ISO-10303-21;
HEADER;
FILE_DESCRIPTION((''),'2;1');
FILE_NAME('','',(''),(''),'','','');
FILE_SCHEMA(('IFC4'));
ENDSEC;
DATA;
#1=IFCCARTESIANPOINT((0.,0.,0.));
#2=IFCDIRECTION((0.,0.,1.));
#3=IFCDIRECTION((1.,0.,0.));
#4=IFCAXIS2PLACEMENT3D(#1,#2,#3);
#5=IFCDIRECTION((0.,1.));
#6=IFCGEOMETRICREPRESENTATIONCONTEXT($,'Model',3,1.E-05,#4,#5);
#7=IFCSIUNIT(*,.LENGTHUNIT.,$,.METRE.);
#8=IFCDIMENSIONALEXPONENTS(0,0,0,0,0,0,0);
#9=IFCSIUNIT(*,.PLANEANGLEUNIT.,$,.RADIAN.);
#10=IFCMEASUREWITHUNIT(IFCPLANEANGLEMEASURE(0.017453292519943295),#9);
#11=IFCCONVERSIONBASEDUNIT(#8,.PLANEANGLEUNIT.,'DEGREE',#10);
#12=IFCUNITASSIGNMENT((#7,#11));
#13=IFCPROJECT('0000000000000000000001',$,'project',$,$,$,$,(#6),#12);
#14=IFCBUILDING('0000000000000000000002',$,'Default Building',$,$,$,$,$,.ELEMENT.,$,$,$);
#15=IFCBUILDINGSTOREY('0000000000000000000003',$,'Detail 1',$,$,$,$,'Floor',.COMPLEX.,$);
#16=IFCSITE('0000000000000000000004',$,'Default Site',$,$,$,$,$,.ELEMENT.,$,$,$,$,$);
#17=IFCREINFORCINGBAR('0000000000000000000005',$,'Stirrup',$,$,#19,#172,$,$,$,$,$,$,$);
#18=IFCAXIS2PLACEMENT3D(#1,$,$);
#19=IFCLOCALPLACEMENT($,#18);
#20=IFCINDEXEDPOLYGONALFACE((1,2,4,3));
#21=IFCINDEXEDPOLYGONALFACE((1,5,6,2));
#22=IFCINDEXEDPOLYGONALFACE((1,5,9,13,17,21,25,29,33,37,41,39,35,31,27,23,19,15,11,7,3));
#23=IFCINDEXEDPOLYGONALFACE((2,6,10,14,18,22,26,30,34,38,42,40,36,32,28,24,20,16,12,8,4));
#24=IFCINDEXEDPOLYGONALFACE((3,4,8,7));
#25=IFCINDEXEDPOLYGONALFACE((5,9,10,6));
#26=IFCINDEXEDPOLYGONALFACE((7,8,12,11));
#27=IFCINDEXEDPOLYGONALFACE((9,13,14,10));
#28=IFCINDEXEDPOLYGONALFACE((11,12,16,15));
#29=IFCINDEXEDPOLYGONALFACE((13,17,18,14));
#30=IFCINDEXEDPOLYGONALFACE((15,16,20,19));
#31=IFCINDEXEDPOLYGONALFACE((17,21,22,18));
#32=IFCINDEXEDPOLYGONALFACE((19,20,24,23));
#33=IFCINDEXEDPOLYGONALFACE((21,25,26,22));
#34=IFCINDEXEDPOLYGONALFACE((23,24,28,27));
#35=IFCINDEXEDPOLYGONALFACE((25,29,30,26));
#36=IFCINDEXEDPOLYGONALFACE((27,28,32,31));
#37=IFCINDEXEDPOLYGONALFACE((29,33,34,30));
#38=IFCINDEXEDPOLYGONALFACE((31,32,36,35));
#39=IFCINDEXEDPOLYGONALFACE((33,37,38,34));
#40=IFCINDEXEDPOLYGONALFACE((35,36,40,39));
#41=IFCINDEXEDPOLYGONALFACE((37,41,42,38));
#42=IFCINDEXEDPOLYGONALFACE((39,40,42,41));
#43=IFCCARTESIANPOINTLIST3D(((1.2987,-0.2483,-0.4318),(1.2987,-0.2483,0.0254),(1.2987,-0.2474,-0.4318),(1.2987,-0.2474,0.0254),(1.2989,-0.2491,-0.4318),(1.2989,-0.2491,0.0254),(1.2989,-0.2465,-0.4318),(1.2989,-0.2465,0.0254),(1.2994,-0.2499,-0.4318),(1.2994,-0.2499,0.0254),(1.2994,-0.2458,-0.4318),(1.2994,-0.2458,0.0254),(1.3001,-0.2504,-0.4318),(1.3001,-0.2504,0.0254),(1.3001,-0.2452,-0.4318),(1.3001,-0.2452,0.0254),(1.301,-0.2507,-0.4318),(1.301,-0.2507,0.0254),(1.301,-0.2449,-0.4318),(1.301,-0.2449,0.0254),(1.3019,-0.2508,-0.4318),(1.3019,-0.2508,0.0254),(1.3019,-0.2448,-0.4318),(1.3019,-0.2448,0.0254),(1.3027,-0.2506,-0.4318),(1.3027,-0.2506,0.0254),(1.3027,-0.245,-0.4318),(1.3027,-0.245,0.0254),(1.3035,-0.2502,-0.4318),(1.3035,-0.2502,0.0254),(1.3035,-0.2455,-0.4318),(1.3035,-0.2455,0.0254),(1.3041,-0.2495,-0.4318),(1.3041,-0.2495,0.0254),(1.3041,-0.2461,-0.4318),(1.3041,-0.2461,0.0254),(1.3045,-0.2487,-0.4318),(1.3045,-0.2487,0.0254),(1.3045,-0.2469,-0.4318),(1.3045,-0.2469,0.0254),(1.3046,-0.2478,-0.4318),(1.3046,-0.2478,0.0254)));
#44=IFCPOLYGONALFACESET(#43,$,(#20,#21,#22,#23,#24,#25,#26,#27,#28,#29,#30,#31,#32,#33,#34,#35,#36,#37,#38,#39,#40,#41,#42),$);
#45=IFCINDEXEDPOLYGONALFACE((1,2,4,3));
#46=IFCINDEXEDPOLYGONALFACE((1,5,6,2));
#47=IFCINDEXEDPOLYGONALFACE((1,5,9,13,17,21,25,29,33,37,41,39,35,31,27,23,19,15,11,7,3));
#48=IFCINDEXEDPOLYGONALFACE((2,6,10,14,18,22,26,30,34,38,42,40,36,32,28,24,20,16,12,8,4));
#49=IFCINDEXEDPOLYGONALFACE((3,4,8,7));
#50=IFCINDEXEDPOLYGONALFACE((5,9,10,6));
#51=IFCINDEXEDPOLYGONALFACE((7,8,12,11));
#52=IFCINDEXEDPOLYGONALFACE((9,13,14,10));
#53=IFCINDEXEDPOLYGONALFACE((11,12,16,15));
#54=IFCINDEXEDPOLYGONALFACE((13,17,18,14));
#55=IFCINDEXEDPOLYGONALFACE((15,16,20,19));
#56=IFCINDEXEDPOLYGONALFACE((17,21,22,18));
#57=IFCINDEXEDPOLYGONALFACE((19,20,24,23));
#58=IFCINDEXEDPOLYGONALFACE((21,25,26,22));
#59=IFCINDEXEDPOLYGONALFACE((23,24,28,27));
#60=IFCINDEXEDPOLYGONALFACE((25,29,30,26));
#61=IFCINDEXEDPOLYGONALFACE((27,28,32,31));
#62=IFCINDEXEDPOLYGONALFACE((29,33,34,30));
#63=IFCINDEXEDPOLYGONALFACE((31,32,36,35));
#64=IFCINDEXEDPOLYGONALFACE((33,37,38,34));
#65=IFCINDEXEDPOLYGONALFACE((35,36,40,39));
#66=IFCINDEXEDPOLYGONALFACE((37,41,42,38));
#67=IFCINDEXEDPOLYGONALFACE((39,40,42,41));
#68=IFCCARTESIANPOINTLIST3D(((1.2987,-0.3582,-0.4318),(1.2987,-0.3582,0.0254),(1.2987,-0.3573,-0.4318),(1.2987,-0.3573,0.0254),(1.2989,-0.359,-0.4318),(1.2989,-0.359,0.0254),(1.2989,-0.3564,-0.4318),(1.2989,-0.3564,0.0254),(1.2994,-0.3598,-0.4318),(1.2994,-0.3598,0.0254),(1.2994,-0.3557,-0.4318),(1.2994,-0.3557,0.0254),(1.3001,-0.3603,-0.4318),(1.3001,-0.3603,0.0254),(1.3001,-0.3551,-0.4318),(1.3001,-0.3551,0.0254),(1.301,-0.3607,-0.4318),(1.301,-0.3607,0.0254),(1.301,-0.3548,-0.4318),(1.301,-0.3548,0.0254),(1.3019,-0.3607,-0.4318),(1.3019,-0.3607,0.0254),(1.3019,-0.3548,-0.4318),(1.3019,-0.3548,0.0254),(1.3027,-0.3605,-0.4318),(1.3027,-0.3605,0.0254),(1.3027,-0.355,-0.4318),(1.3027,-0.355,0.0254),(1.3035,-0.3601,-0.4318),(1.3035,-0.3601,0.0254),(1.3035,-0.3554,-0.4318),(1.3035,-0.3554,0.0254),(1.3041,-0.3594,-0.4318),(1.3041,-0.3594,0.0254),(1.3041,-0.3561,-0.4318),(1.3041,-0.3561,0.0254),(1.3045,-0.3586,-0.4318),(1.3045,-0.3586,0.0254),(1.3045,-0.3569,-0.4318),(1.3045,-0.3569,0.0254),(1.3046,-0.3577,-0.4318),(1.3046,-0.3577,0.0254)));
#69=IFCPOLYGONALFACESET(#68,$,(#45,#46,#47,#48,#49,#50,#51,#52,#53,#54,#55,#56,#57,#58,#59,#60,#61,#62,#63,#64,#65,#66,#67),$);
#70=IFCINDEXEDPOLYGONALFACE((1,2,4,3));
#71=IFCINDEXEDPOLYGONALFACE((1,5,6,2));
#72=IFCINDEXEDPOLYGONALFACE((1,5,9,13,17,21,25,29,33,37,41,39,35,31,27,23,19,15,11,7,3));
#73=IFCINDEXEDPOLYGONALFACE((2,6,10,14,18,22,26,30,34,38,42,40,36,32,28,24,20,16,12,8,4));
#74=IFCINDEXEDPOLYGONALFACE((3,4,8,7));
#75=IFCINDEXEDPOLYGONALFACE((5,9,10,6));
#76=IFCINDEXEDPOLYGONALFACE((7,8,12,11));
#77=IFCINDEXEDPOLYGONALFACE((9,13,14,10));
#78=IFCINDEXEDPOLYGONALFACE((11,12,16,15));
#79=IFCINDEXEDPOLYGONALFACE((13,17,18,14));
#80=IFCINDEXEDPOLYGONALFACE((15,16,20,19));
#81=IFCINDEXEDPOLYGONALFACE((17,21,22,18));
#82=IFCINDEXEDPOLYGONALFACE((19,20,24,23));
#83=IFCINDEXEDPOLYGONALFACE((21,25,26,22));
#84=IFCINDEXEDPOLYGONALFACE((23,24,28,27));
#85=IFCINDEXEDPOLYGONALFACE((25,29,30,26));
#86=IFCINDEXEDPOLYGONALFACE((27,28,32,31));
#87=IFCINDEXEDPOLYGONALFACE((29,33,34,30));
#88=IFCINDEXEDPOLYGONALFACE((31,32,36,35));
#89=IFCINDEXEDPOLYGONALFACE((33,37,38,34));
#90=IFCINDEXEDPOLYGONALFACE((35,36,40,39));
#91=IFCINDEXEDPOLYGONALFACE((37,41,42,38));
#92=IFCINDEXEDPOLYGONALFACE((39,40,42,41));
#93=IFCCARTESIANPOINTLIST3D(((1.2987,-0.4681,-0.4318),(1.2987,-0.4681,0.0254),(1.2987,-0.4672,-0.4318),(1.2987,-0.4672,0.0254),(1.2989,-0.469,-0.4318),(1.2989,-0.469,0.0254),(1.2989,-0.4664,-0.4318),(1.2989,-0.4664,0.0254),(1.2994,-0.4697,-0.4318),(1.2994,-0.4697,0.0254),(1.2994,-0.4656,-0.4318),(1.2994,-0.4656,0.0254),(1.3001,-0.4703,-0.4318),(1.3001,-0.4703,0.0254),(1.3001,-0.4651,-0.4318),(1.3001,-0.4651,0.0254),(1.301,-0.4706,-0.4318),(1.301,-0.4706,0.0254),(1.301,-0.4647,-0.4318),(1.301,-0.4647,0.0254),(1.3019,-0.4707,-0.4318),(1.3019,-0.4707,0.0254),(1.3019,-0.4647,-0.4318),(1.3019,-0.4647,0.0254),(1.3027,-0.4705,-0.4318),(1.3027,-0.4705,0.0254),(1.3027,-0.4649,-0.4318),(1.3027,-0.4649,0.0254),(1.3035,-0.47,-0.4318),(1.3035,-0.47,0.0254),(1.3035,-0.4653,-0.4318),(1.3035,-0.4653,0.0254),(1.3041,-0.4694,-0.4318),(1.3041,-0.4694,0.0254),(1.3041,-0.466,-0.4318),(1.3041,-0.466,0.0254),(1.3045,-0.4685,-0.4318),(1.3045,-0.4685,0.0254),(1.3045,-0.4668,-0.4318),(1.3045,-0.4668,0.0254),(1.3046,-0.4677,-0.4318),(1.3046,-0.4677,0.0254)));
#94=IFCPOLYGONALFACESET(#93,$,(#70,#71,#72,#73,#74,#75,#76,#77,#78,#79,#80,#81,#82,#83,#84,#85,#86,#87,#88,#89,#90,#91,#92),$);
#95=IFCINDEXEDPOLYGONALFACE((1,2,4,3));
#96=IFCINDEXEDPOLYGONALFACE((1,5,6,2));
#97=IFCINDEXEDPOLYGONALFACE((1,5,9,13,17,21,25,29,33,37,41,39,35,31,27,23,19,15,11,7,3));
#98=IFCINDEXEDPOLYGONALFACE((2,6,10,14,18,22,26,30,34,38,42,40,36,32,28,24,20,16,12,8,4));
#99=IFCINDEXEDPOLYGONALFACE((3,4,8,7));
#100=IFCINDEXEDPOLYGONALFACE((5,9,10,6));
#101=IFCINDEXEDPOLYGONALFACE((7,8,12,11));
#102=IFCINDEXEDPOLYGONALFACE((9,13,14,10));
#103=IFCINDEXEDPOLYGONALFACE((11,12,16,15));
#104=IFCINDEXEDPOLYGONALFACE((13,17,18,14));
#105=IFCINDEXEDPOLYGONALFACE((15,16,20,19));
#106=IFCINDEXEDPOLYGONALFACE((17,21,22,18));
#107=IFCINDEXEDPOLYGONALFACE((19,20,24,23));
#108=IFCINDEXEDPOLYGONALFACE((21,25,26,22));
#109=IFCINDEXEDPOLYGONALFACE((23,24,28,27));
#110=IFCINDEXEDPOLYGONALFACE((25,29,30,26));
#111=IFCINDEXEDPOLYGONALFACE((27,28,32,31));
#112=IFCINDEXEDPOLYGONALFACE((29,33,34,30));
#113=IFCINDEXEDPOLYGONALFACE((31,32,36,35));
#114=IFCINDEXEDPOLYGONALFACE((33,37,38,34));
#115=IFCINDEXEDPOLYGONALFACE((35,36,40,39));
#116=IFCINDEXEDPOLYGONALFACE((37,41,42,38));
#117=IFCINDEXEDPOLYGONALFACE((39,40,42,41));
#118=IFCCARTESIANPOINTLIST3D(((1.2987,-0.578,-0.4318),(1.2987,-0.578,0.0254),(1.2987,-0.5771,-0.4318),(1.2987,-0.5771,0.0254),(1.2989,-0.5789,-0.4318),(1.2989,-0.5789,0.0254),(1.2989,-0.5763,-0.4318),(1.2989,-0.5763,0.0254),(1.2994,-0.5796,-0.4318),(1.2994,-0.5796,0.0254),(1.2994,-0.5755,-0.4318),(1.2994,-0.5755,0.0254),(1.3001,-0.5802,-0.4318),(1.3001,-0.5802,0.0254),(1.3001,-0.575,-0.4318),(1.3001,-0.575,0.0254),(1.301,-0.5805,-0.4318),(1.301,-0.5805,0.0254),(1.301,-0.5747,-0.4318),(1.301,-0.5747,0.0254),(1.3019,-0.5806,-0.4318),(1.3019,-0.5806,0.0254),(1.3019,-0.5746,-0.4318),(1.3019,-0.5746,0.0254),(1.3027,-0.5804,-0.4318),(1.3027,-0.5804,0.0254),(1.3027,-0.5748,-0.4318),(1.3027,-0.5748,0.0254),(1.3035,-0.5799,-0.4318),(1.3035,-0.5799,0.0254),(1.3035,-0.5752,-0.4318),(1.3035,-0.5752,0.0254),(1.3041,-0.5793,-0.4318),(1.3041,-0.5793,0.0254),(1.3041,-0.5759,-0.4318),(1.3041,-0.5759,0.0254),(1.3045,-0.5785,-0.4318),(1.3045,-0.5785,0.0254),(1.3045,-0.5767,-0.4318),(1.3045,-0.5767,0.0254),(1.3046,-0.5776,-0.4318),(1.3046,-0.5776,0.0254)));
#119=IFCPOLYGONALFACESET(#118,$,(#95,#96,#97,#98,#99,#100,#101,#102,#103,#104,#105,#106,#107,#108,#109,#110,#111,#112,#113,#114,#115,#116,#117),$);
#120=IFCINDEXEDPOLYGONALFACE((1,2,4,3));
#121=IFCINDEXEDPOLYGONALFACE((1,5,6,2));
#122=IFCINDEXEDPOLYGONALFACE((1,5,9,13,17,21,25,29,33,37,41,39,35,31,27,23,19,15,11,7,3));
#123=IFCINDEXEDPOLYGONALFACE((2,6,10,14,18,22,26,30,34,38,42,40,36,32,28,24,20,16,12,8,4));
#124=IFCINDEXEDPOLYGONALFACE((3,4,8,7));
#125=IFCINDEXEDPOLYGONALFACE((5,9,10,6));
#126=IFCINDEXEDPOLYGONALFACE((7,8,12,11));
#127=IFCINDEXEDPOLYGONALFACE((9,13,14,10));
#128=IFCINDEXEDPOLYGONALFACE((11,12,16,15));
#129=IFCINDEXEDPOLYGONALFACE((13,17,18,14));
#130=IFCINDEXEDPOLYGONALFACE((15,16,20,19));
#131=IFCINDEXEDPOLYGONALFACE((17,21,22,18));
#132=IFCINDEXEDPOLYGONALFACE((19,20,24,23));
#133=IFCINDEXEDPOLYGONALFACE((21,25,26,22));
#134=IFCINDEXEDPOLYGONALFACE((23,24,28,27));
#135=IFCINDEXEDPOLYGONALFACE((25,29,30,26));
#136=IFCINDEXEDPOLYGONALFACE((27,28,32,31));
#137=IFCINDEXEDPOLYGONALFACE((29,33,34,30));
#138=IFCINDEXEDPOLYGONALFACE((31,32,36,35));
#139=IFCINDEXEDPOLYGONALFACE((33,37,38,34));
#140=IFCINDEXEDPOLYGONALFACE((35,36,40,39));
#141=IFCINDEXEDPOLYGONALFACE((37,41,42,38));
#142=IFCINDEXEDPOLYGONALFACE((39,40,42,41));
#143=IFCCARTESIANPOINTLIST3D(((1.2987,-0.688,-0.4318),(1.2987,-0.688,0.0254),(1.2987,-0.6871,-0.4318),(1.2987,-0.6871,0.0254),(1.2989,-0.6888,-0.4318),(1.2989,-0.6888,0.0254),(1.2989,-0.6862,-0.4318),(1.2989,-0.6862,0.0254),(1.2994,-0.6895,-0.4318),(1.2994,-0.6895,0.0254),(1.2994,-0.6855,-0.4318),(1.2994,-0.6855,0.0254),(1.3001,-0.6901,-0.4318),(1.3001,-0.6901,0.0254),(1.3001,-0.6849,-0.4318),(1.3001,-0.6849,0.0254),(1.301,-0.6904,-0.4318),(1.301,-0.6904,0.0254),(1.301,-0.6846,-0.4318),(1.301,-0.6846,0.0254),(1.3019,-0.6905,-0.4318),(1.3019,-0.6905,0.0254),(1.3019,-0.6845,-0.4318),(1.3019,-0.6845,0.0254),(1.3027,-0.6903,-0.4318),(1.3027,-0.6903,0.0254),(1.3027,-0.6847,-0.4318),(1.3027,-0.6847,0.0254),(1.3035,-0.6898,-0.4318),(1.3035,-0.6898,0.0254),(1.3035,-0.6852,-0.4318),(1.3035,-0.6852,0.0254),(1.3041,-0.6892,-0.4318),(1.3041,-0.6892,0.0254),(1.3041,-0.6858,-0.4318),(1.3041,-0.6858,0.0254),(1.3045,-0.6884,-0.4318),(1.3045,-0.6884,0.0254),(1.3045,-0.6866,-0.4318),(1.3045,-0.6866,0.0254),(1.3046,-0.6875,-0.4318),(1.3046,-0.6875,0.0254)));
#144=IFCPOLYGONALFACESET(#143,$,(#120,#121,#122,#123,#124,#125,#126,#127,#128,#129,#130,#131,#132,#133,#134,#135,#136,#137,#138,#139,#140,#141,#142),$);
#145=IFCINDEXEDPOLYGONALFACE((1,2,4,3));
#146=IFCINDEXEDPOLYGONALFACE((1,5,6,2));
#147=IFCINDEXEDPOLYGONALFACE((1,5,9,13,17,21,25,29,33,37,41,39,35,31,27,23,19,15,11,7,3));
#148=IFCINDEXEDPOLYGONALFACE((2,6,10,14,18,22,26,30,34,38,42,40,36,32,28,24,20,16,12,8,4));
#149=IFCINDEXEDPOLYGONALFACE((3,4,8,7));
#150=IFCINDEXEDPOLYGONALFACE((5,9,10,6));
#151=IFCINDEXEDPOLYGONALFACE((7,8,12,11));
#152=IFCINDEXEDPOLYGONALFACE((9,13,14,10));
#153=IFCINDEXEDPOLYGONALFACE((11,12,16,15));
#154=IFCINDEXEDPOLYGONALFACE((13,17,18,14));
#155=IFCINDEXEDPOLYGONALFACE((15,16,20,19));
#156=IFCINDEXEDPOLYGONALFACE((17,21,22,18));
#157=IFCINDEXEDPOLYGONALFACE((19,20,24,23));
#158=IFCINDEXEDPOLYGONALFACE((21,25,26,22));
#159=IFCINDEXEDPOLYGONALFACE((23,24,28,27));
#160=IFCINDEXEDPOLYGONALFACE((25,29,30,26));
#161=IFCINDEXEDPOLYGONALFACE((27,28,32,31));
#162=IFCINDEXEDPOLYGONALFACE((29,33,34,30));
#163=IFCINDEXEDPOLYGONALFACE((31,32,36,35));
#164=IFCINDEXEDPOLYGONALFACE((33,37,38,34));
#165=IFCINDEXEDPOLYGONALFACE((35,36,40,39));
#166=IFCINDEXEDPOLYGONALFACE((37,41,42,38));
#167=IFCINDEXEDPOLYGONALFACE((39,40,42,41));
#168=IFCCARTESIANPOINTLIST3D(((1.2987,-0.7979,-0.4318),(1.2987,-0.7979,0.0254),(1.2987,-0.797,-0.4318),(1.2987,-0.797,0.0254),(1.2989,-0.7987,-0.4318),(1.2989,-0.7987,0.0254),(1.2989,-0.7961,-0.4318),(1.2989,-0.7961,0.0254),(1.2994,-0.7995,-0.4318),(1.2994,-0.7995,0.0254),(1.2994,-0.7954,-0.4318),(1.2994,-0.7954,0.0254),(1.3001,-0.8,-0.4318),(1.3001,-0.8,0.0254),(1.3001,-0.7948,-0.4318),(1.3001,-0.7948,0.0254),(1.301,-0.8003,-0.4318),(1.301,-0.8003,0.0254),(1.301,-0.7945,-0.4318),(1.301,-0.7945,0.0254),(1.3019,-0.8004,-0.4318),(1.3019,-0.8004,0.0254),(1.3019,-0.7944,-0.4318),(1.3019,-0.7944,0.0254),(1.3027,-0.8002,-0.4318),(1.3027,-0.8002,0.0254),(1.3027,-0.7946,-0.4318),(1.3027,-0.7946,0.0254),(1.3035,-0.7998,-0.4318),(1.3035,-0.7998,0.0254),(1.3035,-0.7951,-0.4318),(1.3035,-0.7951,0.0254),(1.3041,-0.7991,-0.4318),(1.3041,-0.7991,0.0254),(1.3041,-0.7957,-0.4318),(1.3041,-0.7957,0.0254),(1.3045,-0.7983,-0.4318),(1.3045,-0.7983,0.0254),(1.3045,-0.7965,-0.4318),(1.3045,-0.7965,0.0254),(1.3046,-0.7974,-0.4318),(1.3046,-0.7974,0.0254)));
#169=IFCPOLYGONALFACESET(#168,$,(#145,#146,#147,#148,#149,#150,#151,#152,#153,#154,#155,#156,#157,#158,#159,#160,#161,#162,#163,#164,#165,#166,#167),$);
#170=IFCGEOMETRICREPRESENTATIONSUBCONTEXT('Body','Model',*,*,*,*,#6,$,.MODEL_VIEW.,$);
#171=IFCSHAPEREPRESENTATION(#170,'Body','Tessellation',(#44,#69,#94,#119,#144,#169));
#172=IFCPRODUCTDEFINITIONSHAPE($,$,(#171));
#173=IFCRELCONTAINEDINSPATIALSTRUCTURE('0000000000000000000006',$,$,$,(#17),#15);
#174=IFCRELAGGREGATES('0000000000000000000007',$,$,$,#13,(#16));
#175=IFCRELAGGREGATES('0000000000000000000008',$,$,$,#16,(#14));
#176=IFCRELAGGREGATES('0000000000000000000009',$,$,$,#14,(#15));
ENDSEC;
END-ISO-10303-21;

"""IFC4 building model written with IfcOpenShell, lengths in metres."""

from ifc_helpers import new_model, entity, si_unit, converted_unit, direction, origin_with_axes, place, context, subcontext, project, spatial, element, save


model = new_model("IFC4")

# Units and contexts
model_context = context("Model", 3, precision=1e-05, world=origin_with_axes(), true_north=direction((0.0, 1.0)))
body_context = subcontext(model_context, "Body", "Model", "MODEL_VIEW")
ifc_project = project(units=[si_unit("LENGTHUNIT", "METRE"), converted_unit("PLANEANGLEUNIT", "DEGREE", entity("IfcPlaneAngleMeasure", 0.017453292519943295), si_unit("PLANEANGLEUNIT", "RADIAN"), dimensions=[0, 0, 0, 0, 0, 0, 0])], contexts=[model_context])

# Site, building, storey
site = spatial("IfcSite", under=ifc_project, Name="Default Site", CompositionType="ELEMENT")
building = spatial("IfcBuilding", under=site, Name="Default Building", CompositionType="ELEMENT")
storey = spatial("IfcBuildingStorey", under=building, Name="Detail 1", LongName="Floor", CompositionType="COMPLEX")

# Shared definitions
placement = place(None, origin_with_axes())

# Reinforcing bar
element("IfcReinforcingBar", 1, at=placement, inside=storey, Name="Stirrup", context=body_context, shape_type="SweptSolid", body=[
    entity("IfcSweptDiskSolid", entity("IfcCompositeCurve", [entity("IfcCompositeCurveSegment", "CONTINUOUS", True, entity("IfcPolyline", [entity("IfcCartesianPoint", [1.3016, -0.2478, -0.4318]), entity("IfcCartesianPoint", [1.3016, -0.2478, 0.0254])]))], False), 0.003),
    entity("IfcSweptDiskSolid", entity("IfcCompositeCurve", [entity("IfcCompositeCurveSegment", "CONTINUOUS", True, entity("IfcPolyline", [entity("IfcCartesianPoint", [1.3016, -0.3577, -0.4318]), entity("IfcCartesianPoint", [1.3016, -0.3577, 0.0254])]))], False), 0.003),
    entity("IfcSweptDiskSolid", entity("IfcCompositeCurve", [entity("IfcCompositeCurveSegment", "CONTINUOUS", True, entity("IfcPolyline", [entity("IfcCartesianPoint", [1.3016, -0.4677, -0.4318]), entity("IfcCartesianPoint", [1.3016, -0.4677, 0.0254])]))], False), 0.003),
    entity("IfcSweptDiskSolid", entity("IfcCompositeCurve", [entity("IfcCompositeCurveSegment", "CONTINUOUS", True, entity("IfcPolyline", [entity("IfcCartesianPoint", [1.3016, -0.5776, -0.4318]), entity("IfcCartesianPoint", [1.3016, -0.5776, 0.0254])]))], False), 0.003),
    entity("IfcSweptDiskSolid", entity("IfcCompositeCurve", [entity("IfcCompositeCurveSegment", "CONTINUOUS", True, entity("IfcPolyline", [entity("IfcCartesianPoint", [1.3016, -0.6875, -0.4318]), entity("IfcCartesianPoint", [1.3016, -0.6875, 0.0254])]))], False), 0.003),
    entity("IfcSweptDiskSolid", entity("IfcCompositeCurve", [entity("IfcCompositeCurveSegment", "CONTINUOUS", True, entity("IfcPolyline", [entity("IfcCartesianPoint", [1.3016, -0.7974, -0.4318]), entity("IfcCartesianPoint", [1.3016, -0.7974, 0.0254])]))], False), 0.003),
])

save(model, "model.ifc")
